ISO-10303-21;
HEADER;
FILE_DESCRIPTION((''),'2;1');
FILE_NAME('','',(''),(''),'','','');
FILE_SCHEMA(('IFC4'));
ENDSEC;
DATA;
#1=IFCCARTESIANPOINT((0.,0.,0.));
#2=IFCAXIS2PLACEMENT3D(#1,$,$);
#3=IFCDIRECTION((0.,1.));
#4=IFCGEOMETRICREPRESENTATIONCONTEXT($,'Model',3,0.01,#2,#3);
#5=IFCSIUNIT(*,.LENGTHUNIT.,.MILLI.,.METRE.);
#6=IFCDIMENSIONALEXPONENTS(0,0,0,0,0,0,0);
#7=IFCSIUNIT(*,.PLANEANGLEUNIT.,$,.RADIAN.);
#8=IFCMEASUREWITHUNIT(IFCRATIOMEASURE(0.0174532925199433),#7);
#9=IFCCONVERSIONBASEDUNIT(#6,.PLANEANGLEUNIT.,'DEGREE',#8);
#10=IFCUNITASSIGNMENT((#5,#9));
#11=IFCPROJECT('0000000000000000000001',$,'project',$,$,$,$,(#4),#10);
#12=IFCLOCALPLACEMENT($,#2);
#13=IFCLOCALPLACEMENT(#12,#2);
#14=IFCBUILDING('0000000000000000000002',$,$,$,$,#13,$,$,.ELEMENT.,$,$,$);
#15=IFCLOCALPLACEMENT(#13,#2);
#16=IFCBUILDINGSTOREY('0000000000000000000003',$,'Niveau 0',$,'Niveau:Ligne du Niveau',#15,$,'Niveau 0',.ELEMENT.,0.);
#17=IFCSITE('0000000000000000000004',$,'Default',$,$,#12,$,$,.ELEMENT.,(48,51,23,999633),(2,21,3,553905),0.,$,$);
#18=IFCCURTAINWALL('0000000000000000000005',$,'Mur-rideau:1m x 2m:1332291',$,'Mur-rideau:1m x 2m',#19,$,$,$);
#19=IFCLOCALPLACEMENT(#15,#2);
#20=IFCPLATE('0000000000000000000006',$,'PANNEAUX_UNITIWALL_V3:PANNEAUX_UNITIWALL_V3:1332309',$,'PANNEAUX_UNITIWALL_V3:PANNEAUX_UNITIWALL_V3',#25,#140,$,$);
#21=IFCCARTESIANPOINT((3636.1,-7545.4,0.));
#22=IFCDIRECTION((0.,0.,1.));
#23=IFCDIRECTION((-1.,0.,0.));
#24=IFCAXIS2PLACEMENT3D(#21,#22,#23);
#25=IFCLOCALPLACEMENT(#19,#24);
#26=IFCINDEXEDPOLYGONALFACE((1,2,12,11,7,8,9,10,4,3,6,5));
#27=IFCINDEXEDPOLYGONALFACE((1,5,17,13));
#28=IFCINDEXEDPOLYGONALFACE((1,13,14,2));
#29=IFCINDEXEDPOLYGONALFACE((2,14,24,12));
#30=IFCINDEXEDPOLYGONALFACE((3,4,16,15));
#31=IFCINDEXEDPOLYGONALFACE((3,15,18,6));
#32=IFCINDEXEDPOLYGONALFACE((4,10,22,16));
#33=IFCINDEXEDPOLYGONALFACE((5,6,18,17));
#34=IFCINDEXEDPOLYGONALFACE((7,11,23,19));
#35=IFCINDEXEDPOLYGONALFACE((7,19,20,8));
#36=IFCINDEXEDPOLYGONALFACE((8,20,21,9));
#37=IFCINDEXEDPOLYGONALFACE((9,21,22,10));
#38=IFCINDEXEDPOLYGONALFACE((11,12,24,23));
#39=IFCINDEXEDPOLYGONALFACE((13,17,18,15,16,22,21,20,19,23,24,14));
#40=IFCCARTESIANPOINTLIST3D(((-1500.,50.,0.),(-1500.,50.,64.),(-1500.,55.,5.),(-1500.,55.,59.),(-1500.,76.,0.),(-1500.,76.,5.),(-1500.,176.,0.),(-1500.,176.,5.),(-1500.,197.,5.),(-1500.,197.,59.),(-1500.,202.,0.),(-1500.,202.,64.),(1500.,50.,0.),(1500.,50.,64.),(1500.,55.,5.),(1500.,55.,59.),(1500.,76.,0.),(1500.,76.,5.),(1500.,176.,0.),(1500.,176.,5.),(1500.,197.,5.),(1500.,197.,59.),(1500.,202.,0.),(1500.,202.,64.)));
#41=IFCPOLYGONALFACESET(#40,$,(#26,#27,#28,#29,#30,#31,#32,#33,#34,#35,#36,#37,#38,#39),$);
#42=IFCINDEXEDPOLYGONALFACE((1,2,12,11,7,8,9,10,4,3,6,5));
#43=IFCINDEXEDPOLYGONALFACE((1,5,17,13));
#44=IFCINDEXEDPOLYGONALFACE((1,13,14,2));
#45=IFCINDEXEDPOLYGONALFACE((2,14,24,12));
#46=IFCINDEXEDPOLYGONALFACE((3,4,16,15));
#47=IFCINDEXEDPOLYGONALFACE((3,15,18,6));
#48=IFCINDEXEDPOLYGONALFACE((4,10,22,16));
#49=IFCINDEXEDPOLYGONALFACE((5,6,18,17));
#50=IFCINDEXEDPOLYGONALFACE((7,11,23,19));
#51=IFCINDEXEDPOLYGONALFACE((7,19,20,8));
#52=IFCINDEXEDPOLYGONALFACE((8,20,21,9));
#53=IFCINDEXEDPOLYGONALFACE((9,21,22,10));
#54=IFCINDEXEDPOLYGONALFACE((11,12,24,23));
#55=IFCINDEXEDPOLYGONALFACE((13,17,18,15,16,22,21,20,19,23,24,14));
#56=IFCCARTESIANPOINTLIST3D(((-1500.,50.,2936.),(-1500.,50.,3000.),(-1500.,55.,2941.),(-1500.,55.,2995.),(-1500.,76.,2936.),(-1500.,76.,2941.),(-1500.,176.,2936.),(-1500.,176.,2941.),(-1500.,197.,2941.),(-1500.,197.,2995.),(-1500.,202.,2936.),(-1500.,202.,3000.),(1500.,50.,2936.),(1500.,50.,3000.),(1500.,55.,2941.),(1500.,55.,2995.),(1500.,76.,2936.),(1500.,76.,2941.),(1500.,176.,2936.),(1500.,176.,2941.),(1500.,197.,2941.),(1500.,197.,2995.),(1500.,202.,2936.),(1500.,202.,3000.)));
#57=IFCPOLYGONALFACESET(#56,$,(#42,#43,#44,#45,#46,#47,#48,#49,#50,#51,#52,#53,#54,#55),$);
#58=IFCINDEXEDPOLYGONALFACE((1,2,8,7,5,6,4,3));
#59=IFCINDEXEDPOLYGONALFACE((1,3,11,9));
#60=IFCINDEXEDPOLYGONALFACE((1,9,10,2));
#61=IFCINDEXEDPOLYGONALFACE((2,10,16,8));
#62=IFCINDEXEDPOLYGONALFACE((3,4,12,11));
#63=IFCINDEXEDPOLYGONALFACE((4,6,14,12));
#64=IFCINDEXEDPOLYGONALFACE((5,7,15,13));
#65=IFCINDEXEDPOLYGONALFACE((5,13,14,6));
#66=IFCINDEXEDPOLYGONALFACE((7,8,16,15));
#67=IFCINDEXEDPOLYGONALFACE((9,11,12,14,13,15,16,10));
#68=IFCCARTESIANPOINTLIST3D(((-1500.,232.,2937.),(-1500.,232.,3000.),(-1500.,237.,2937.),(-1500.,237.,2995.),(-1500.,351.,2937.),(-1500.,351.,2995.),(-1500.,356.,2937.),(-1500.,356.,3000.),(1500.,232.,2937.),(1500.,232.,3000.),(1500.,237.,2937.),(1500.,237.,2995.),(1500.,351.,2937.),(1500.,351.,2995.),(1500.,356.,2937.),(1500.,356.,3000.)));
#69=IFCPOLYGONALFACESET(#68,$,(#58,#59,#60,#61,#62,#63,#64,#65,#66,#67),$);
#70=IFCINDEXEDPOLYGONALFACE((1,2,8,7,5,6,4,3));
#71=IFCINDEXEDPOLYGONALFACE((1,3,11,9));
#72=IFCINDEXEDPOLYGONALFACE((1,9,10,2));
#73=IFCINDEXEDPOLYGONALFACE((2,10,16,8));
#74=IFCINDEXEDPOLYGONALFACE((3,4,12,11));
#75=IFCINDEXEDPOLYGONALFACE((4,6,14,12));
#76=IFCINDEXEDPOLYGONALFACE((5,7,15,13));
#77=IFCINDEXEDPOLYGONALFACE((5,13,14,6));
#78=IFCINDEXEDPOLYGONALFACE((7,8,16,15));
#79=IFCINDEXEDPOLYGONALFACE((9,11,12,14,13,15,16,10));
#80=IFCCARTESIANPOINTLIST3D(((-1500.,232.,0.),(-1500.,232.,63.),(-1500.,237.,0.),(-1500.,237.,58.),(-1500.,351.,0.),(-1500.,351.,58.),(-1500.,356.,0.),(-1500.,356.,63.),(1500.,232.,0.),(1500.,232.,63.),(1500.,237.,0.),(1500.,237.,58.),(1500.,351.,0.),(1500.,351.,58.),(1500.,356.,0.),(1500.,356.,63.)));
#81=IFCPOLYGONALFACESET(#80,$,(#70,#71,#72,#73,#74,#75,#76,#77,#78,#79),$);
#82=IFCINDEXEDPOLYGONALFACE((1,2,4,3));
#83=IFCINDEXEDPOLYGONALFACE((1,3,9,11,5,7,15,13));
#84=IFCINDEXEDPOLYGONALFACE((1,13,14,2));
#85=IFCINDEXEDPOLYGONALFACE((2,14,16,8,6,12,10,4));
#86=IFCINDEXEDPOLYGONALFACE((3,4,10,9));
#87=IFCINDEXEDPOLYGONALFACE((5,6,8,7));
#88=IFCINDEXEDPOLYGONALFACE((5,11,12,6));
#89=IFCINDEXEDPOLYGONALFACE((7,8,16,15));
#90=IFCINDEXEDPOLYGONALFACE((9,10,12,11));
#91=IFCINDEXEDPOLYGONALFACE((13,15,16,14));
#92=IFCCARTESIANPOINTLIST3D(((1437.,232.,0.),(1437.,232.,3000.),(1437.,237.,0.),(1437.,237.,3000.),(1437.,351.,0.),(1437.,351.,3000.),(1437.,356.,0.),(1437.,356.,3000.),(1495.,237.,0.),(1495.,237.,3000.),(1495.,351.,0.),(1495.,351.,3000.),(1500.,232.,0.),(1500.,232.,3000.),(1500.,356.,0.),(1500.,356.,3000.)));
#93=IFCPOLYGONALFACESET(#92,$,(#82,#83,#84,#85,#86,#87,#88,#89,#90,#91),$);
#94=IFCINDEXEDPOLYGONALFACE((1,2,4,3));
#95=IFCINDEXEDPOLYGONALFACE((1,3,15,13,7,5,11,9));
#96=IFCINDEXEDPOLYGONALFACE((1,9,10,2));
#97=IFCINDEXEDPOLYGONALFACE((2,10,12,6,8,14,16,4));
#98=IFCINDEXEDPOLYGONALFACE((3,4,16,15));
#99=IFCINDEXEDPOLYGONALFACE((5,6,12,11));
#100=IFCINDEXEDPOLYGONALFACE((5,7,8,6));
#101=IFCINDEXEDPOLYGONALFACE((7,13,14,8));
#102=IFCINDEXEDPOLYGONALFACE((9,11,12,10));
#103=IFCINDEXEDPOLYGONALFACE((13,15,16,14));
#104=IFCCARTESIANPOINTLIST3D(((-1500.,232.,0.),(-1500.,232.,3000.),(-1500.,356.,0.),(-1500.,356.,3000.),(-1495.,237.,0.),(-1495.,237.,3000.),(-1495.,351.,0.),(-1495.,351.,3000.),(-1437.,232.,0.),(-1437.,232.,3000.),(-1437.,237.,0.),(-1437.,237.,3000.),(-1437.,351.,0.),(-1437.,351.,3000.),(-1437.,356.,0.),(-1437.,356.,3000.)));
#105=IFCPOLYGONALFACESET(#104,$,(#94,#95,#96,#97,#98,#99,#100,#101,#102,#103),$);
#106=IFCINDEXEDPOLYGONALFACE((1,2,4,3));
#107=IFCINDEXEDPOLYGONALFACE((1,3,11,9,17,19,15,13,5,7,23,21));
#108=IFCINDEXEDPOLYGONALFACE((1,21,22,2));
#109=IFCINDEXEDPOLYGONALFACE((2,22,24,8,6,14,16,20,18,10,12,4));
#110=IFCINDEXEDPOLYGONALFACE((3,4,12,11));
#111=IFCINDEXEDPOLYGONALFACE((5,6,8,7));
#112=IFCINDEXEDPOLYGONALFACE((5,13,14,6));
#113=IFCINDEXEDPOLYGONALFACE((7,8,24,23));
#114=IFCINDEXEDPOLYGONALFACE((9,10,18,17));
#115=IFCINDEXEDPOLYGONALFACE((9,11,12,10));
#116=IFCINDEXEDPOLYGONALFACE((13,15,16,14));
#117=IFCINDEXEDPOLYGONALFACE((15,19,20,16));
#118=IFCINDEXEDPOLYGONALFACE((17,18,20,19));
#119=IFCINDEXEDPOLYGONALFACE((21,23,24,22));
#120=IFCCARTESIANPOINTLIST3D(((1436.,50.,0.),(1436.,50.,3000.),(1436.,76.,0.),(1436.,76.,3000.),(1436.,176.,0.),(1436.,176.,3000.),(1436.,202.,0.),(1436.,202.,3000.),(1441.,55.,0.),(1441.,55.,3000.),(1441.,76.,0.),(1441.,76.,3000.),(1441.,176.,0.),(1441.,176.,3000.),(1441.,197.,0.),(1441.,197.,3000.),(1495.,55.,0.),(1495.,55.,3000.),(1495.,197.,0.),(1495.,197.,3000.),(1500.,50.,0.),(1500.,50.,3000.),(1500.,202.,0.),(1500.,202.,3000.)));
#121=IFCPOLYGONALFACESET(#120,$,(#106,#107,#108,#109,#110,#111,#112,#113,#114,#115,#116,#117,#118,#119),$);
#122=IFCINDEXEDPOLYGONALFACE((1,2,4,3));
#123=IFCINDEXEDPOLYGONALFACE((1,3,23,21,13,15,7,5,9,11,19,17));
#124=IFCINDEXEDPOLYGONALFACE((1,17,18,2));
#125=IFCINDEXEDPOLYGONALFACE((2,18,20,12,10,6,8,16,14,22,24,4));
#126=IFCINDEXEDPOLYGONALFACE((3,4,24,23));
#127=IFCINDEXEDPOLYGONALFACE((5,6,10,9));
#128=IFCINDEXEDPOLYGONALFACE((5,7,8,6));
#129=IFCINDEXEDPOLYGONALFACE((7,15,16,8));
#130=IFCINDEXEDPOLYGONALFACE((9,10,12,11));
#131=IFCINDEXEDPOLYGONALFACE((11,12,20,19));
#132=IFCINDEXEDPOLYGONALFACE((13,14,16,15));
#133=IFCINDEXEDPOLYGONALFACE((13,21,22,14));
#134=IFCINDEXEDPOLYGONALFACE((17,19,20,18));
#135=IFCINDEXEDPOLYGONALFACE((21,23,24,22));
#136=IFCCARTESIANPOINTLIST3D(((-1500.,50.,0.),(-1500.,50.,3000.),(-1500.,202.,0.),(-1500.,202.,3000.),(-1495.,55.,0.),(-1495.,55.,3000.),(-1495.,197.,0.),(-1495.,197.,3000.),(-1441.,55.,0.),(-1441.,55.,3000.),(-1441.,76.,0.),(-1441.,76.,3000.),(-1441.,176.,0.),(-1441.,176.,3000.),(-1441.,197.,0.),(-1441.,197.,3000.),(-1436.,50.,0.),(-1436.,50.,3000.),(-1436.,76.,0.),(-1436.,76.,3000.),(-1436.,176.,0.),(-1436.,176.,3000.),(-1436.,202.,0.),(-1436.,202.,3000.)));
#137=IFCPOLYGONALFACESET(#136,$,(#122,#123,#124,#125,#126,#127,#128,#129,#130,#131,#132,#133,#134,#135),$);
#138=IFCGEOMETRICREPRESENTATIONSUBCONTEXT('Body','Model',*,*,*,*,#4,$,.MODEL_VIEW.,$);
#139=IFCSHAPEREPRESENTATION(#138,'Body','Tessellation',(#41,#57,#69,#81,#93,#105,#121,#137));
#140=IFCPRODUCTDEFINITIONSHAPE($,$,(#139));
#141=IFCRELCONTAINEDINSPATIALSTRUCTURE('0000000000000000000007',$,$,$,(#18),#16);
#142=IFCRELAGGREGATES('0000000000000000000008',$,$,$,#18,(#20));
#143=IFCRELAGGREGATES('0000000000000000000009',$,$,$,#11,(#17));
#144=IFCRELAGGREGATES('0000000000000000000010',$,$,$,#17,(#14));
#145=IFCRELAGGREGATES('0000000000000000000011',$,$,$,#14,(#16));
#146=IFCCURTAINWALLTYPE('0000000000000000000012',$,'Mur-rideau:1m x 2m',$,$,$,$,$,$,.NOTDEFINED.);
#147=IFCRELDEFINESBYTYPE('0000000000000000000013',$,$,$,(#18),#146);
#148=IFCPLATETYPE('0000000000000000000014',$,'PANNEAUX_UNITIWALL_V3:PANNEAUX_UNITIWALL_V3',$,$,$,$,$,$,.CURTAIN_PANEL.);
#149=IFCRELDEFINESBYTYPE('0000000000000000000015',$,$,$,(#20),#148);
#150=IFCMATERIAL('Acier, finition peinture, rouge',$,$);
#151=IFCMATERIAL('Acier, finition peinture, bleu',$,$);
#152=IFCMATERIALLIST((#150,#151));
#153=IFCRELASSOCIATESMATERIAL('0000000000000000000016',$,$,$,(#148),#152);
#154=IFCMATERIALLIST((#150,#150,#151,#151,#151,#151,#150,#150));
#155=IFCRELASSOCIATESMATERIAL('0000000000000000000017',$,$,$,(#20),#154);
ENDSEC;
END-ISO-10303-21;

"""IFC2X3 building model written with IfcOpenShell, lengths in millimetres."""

from ifc_helpers import new_model, entity, si_unit, converted_unit, direction, frame, origin, place, context, subcontext, project, spatial, polyline, outline, extrude, source, transform, mapped, material, material_list, type_object, type_shapes, element, aggregate, save


model = new_model("IFC2X3")

# Units and contexts
model_context = context("Model", 3, precision=0.01, world=origin(), true_north=direction((0.0, 1.0)))
body_context = subcontext(model_context, "Body", "Model", "MODEL_VIEW")
ifc_project = project(units=[si_unit("LENGTHUNIT", "METRE", prefix="MILLI"), converted_unit("PLANEANGLEUNIT", "DEGREE", entity("IfcRatioMeasure", 0.0174532925199433), si_unit("PLANEANGLEUNIT", "RADIAN"), dimensions=[0, 0, 0, 0, 0, 0, 0])], contexts=[model_context])

# Site, building, storey
site_placement = place(None, origin())
site = spatial("IfcSite", under=ifc_project, at=site_placement, Name="Default", CompositionType="ELEMENT", RefLatitude=(48, 51, 23, 999633), RefLongitude=(2, 21, 3, 553905), RefElevation=0.0)
building_placement = place(site_placement, origin())
building = spatial("IfcBuilding", under=site, at=building_placement, CompositionType="ELEMENT")
storey_placement = place(building_placement, origin())
storey = spatial("IfcBuildingStorey", under=building, at=storey_placement, Name="Niveau 0", ObjectType="Niveau:Ligne du Niveau", LongName="Niveau 0", CompositionType="ELEMENT", Elevation=0.0)

# Curtain wall, plate
curtain_wall_type_1 = type_object("IfcCurtainWallType", Name="Mur-rideau:1m x 2m", PredefinedType="NOTDEFINED")
curtain_wall_1_placement = place(storey_placement, origin())
curtain_wall_1 = element("IfcCurtainWall", 1, at=curtain_wall_1_placement, inside=storey, type_object=curtain_wall_type_1, Name="Mur-rideau:1m x 2m:1332291", ObjectType="Mur-rideau:1m x 2m")
ifc_material_1 = material(Name="Acier, finition peinture, bleu")
ifc_material_2 = material(Name="Acier, finition peinture, rouge")
ifc_material_list_1 = material_list([ifc_material_2, ifc_material_2, ifc_material_1, ifc_material_1, ifc_material_1, ifc_material_1, ifc_material_2, ifc_material_2])
ifc_material_list_2 = material_list([ifc_material_2, ifc_material_1])
plate_type_1 = type_object("IfcPlateType", Name="PANNEAUX_UNITIWALL_V3:PANNEAUX_UNITIWALL_V3", PredefinedType="CURTAIN_PANEL", material=ifc_material_list_2)
shared_shape_1 = source(origin(), body_context, "Body", "SweptSolid", [
    extrude(outline(polyline([(-41.8, -76.0), (22.2, -76.0), (22.2, -50.0), (17.2, -50.0), (17.2, -71.0), (-36.8, -71.0), (-36.8, 71.0), (17.2, 71.0), (17.2, 50.0), (22.2, 50.0), (22.2, 76.0), (-41.8, 76.0), (-41.8, -76.0)])), frame((-1500.0, 126.0, 22.2), z_axis=(1.0, 0.0, 0.0), x_axis=(0.0, 0.0, -1.0)), (0.0, 0.0, 1.0), 3000.0),
    extrude(outline(polyline([(-41.8, -76.0), (22.2, -76.0), (22.2, -50.0), (17.2, -50.0), (17.2, -71.0), (-36.8, -71.0), (-36.8, 71.0), (17.2, 71.0), (17.2, 50.0), (22.2, 50.0), (22.2, 76.0), (-41.8, 76.0), (-41.8, -76.0)])), frame((-1500.0, 126.0, 2958.2), z_axis=(1.0, 0.0, 0.0), x_axis=(0.0, 0.0, -1.0)), (0.0, 0.0, 1.0), 3000.0),
    extrude(outline(polyline([(-62.0, -32.8), (62.0, -32.8), (62.0, 30.2), (57.0, 30.2), (57.0, -27.8), (-57.0, -27.8), (-57.0, 30.2), (-62.0, 30.2), (-62.0, -32.8)])), frame((-1500.0, 294.0, 2967.3), z_axis=(1.0, 0.0, 0.0), x_axis=(0.0, -1.0, 0.0)), (0.0, 0.0, 1.0), 3000.0),
    extrude(outline(polyline([(-62.0, -32.8), (62.0, -32.8), (62.0, 30.2), (57.0, 30.2), (57.0, -27.8), (-57.0, -27.8), (-57.0, 30.2), (-62.0, 30.2), (-62.0, -32.8)])), frame((-1500.0, 294.0, 30.3), z_axis=(1.0, 0.0, 0.0), x_axis=(0.0, -1.0, 0.0)), (0.0, 0.0, 1.0), 3000.0),
    extrude(outline(polyline([(-62.0, -32.8), (62.0, -32.8), (62.0, 30.2), (57.0, 30.2), (57.0, -27.8), (-57.0, -27.8), (-57.0, 30.2), (-62.0, 30.2), (-62.0, -32.8)])), frame((1467.3, 294.0, 0.0), z_axis=(0.0, 0.0, 1.0), x_axis=(0.0, 1.0, 0.0)), (0.0, 0.0, 1.0), 3000.0),
    extrude(outline(polyline([(-32.8, -62.0), (30.2, -62.0), (30.2, -57.0), (-27.8, -57.0), (-27.8, 57.0), (30.2, 57.0), (30.2, 62.0), (-32.8, 62.0), (-32.8, -62.0)])), frame((-1467.3, 294.0, 0.0)), (0.0, 0.0, 1.0), 3000.0),
    extrude(outline(polyline([(-76.0, -41.8), (76.0, -41.8), (76.0, 22.2), (50.0, 22.2), (50.0, 17.2), (71.0, 17.2), (71.0, -36.8), (-71.0, -36.8), (-71.0, 17.2), (-50.0, 17.2), (-50.0, 22.2), (-76.0, 22.2), (-76.0, -41.8)])), frame((1458.2, 126.0, 0.0), z_axis=(0.0, 0.0, 1.0), x_axis=(0.0, 1.0, 0.0)), (0.0, 0.0, 1.0), 3000.0),
    extrude(outline(polyline([(-76.0, -41.8), (76.0, -41.8), (76.0, 22.2), (50.0, 22.2), (50.0, 17.2), (71.0, 17.2), (71.0, -36.8), (-71.0, -36.8), (-71.0, 17.2), (-50.0, 17.2), (-50.0, 22.2), (-76.0, 22.2), (-76.0, -41.8)])), frame((-1458.2, 126.0, 0.0), z_axis=(0.0, 0.0, 1.0), x_axis=(0.0, -1.0, 0.0)), (0.0, 0.0, 1.0), 3000.0),
])
type_shapes(plate_type_1, [shared_shape_1])
plate_1_placement = place(curtain_wall_1_placement, frame((3636.1, -7545.4, 0.0), z_axis=(0.0, 0.0, 1.0), x_axis=(-1.0, 0.0, 0.0)))
plate_1 = element("IfcPlate", 2, at=plate_1_placement, type_object=plate_type_1, material=ifc_material_list_1, Name="PANNEAUX_UNITIWALL_V3:PANNEAUX_UNITIWALL_V3:1332309", ObjectType="PANNEAUX_UNITIWALL_V3:PANNEAUX_UNITIWALL_V3", context=body_context, shape_type="MappedRepresentation", body=[
    mapped(shared_shape_1, transform((0.0, 0.0, 0.0), scale=1.0)),
])
aggregate(curtain_wall_1, [plate_1])

save(model, "model.ifc")
